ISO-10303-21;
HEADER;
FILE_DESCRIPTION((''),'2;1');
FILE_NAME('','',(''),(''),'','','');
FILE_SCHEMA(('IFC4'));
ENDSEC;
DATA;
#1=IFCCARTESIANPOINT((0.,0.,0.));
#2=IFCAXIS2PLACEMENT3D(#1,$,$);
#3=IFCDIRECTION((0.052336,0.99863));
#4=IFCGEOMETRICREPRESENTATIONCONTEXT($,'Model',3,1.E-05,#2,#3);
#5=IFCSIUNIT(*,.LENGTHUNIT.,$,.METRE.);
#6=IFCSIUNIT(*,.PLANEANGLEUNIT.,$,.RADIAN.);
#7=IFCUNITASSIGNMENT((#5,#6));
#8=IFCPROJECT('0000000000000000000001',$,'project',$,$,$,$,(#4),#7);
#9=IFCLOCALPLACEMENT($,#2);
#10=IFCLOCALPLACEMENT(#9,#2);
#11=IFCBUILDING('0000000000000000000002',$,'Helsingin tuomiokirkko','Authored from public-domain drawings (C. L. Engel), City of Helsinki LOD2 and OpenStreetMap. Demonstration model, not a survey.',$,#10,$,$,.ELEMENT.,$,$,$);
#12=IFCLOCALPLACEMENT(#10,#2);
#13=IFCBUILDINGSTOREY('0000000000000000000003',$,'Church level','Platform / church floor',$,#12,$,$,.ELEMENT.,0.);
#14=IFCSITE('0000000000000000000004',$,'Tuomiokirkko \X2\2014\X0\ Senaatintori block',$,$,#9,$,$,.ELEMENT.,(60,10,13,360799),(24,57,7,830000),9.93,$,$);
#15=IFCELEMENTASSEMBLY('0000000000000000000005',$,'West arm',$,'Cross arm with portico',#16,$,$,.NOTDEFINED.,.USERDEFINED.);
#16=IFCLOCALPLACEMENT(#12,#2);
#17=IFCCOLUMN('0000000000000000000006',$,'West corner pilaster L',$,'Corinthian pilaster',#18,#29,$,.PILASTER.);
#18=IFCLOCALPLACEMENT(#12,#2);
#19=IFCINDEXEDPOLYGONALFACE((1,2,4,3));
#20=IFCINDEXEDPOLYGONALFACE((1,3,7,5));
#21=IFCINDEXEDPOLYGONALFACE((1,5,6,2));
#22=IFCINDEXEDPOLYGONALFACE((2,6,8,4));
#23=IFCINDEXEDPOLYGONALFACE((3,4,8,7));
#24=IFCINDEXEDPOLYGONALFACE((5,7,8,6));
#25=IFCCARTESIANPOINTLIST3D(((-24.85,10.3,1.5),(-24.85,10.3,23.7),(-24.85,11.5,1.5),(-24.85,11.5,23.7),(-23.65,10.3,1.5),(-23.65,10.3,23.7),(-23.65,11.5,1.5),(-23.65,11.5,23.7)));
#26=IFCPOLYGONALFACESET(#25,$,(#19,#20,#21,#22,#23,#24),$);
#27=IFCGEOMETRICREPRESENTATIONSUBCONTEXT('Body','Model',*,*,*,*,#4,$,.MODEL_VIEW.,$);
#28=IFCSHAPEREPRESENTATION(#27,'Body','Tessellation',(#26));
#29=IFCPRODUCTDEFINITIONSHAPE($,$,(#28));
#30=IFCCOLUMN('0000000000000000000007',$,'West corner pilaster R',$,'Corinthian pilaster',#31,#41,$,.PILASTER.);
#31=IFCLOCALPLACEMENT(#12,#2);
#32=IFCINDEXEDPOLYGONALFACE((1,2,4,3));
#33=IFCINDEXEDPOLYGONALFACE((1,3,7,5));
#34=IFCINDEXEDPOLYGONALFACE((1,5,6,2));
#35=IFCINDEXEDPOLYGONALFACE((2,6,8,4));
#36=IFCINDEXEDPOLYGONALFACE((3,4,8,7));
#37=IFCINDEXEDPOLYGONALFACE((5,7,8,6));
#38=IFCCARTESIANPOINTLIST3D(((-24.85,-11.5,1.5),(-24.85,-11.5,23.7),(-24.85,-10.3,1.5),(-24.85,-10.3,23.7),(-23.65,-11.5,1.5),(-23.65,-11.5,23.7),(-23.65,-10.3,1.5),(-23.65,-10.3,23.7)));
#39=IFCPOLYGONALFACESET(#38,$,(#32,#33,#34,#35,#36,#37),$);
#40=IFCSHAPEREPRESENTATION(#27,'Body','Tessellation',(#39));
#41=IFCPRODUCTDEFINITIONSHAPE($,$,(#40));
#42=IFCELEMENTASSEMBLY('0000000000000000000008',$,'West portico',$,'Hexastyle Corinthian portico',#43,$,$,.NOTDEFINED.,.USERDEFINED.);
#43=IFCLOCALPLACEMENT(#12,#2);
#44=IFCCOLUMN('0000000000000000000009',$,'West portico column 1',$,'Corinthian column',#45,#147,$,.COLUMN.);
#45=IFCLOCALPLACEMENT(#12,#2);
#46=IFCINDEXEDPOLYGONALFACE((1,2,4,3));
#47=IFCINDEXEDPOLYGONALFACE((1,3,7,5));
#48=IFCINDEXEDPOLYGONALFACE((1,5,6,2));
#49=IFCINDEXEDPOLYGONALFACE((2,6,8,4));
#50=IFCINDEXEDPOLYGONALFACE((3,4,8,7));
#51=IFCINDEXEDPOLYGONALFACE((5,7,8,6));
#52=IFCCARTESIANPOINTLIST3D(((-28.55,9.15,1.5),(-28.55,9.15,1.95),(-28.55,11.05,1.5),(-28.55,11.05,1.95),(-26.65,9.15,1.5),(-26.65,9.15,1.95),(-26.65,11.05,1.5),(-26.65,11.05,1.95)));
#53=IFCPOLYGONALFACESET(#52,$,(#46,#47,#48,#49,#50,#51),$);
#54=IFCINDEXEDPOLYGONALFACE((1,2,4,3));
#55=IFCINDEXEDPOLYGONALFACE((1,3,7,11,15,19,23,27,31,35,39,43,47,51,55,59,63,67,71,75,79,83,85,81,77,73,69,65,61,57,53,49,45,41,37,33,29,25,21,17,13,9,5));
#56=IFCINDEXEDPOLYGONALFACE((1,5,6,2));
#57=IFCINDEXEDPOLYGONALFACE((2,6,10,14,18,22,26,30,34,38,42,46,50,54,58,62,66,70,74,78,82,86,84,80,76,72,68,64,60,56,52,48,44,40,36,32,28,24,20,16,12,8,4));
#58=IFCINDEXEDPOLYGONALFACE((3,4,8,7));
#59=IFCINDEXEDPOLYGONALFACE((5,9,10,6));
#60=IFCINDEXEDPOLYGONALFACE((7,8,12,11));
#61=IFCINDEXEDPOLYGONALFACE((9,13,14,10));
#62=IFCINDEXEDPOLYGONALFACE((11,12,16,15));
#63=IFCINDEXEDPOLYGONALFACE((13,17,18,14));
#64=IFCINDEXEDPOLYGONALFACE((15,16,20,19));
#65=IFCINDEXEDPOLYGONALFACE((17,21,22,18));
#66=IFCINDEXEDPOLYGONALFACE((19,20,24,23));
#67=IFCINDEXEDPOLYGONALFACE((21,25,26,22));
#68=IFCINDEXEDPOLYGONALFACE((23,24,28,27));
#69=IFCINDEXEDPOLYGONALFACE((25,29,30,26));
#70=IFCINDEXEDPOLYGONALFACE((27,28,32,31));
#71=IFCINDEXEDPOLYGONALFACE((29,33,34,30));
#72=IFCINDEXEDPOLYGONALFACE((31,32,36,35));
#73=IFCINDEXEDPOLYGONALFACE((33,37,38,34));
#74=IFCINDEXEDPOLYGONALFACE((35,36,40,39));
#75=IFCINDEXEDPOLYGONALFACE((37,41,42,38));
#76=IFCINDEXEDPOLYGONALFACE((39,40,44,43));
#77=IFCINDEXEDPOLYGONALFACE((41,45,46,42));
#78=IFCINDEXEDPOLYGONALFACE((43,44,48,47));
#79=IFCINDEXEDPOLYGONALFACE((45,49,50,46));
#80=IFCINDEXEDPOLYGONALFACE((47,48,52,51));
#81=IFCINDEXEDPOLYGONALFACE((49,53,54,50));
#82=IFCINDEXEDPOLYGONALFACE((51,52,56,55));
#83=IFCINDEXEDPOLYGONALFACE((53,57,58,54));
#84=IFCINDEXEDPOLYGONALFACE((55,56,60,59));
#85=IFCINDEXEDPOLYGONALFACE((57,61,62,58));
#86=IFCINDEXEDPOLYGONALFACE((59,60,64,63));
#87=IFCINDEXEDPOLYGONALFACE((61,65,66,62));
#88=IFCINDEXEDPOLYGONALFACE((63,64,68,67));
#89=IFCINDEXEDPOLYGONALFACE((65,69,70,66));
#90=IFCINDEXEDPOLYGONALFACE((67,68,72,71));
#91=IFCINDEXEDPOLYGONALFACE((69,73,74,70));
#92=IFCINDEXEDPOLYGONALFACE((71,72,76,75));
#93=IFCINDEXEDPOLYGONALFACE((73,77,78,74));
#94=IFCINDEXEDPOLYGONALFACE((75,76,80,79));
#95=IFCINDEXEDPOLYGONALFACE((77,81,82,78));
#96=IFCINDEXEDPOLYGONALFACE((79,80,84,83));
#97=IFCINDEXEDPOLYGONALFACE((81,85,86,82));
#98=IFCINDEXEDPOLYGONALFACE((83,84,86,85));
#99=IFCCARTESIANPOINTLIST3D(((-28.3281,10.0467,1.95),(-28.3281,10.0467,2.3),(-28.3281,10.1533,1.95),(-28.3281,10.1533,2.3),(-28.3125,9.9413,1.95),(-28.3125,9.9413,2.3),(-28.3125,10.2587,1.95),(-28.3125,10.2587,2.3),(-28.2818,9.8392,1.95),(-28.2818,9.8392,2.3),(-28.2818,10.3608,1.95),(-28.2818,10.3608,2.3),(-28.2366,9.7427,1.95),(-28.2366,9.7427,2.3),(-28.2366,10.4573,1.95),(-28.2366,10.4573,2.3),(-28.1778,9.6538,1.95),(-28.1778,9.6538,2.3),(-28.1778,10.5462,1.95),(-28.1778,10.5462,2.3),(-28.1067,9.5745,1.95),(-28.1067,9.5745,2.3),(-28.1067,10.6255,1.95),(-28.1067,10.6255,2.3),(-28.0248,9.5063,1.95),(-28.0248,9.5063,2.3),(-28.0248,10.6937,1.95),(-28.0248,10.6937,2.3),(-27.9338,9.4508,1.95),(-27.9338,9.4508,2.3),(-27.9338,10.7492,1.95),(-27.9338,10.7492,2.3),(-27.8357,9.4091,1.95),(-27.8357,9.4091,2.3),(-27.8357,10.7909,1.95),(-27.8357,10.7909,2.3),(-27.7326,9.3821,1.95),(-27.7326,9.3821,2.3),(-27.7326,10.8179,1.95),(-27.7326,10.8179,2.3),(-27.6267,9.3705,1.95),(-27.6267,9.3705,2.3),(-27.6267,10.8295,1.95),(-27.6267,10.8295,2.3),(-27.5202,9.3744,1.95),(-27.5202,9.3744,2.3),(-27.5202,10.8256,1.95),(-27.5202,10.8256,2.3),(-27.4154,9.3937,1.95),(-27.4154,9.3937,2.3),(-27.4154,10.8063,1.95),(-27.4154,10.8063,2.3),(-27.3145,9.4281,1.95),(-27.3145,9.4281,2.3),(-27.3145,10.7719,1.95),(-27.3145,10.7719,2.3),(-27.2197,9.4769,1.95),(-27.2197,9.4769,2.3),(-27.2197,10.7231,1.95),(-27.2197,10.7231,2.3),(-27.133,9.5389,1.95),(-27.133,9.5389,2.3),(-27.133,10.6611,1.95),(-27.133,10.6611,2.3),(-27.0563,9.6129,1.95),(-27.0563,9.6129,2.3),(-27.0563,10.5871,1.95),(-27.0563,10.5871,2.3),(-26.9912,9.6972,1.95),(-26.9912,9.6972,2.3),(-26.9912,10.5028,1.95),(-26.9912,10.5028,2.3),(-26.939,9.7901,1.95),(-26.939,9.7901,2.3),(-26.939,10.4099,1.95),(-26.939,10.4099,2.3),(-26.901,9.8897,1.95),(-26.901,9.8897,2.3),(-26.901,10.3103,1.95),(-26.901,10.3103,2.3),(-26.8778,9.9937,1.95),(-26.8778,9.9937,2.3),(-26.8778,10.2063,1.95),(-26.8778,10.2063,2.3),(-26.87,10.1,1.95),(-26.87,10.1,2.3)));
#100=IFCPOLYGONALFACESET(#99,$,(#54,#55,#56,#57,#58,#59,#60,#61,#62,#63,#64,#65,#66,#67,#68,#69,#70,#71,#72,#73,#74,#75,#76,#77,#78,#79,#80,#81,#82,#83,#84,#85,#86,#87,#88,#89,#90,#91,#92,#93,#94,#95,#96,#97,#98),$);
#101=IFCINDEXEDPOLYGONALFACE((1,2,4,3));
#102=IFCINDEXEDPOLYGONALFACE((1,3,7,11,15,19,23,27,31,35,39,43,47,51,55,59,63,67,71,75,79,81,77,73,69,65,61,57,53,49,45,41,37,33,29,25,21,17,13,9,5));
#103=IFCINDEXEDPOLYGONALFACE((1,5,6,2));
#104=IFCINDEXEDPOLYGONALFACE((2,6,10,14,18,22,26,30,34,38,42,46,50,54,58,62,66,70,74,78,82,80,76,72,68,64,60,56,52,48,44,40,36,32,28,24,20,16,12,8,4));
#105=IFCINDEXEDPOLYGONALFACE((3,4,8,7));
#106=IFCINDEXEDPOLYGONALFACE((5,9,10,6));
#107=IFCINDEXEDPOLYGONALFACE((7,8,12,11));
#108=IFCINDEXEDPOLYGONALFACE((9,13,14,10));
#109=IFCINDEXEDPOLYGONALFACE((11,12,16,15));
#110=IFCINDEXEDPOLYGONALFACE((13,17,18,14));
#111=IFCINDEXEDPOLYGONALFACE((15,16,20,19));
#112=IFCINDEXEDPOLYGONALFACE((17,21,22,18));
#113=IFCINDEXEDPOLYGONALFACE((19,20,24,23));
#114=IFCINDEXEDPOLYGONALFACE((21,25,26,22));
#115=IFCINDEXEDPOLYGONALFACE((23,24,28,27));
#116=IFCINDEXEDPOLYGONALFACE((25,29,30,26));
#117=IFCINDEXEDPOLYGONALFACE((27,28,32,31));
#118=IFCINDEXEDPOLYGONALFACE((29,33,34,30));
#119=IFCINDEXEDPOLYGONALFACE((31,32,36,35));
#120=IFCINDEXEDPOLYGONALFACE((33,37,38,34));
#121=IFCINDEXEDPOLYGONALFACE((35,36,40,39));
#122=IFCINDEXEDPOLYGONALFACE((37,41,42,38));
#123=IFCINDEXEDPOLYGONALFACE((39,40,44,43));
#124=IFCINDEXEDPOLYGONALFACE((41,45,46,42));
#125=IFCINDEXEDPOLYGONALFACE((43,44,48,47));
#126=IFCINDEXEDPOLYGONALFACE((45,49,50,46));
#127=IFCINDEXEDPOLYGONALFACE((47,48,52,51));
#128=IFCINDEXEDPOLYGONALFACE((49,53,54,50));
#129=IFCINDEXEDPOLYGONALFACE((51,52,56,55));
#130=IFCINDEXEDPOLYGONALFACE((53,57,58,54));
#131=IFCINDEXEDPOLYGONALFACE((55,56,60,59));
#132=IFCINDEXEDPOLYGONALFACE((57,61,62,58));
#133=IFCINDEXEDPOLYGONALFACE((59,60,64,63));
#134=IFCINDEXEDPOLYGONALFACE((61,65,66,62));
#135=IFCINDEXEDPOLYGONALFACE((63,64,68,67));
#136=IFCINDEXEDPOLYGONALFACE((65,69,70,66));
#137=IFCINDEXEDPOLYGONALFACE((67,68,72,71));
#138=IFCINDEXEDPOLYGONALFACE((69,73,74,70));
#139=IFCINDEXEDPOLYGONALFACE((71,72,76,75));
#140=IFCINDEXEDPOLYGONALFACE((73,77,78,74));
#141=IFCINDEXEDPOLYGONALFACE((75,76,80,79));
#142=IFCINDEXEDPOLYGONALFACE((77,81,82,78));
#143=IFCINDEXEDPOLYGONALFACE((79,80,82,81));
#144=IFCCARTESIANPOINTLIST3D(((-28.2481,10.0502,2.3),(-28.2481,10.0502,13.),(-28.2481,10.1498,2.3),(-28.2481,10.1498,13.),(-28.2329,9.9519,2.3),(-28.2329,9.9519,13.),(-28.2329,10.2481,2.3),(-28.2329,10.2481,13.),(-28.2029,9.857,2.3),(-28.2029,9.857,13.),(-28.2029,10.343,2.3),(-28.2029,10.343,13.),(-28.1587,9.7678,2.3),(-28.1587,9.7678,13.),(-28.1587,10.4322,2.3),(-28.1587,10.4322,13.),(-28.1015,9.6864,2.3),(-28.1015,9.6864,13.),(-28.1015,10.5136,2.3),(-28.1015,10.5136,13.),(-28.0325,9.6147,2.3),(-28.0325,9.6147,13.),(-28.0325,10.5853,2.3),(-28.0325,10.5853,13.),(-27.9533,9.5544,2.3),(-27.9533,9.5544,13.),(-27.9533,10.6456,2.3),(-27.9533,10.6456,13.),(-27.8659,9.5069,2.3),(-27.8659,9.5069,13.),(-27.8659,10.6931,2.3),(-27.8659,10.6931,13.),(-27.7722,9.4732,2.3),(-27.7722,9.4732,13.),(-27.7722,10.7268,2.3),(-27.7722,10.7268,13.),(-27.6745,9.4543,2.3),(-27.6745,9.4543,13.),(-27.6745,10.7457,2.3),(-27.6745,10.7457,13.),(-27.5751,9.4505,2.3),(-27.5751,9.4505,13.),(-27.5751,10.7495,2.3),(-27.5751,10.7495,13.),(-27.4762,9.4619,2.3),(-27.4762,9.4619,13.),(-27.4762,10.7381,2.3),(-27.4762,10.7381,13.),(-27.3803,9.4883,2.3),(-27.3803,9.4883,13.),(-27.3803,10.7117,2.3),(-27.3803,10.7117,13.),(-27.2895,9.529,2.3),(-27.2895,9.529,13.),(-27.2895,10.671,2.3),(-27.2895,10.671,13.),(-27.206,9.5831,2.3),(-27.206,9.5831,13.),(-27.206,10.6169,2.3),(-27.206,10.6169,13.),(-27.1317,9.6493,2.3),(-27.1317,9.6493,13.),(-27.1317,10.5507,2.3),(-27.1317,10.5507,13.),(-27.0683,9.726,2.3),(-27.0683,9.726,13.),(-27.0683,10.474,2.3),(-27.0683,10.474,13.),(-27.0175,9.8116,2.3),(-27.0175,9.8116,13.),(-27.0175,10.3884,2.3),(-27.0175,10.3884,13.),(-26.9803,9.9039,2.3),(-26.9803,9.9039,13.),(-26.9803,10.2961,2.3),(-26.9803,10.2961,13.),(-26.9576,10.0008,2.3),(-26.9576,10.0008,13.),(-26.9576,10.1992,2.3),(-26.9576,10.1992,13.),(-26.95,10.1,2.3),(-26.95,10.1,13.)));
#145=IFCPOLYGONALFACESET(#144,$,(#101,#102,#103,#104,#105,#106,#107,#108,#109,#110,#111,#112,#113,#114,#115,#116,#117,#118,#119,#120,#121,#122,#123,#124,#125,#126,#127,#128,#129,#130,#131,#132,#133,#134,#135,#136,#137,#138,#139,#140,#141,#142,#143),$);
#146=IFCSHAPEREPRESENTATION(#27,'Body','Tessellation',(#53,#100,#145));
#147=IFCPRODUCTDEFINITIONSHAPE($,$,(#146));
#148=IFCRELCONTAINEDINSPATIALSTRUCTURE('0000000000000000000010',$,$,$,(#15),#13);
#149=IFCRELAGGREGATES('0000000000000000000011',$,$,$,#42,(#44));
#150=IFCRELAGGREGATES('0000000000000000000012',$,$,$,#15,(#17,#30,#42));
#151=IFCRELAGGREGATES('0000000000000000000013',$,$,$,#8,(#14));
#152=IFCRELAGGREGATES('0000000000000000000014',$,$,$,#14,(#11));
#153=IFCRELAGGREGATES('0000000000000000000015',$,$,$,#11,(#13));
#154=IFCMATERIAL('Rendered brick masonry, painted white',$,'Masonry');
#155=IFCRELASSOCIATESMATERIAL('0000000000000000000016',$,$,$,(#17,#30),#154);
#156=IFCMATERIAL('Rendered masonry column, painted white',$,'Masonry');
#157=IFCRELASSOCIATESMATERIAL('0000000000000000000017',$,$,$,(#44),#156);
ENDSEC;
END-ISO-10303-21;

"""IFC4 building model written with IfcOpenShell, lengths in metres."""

from ifc_helpers import new_model, si_unit, direction, frame, origin, origin_2d_with_axis, place, context, subcontext, project, spatial, rectangle, circle, extrude, material, element, aggregate, save


model = new_model("IFC4")

# Units and contexts
model_context = context("Model", 3, precision=1e-05, world=origin(), true_north=direction((0.052336, 0.99863)))
body_context = subcontext(model_context, "Body", "Model", "MODEL_VIEW")
ifc_project = project(units=[si_unit("LENGTHUNIT", "METRE"), si_unit("PLANEANGLEUNIT", "RADIAN")], contexts=[model_context])

# Site, building, storey
site_placement = place(None, origin())
site = spatial("IfcSite", under=ifc_project, at=site_placement, Name="Tuomiokirkko — Senaatintori block", CompositionType="ELEMENT", RefLatitude=(60, 10, 13, 360799), RefLongitude=(24, 57, 7, 830000), RefElevation=9.93)
building_placement = place(site_placement, origin())
building = spatial("IfcBuilding", under=site, at=building_placement, Name="Helsingin tuomiokirkko", Description="Authored from public-domain drawings (C. L. Engel), City of Helsinki LOD2 and OpenStreetMap. Demonstration model, not a survey.", CompositionType="ELEMENT")
storey_placement = place(building_placement, origin())
storey = spatial("IfcBuildingStorey", under=building, at=storey_placement, Name="Church level", Description="Platform / church floor", CompositionType="ELEMENT", Elevation=0.0)

# Element assemblies, columns
assembly_1_placement = place(building_placement, origin())
assembly_1 = element("IfcElementAssembly", 1, at=assembly_1_placement, inside=storey, Name="West arm", ObjectType="Cross arm with portico", AssemblyPlace="NOTDEFINED", PredefinedType="USERDEFINED")
ifc_material_1 = material(Name="Rendered brick masonry, painted white", Category="Masonry")
column_1_placement = place(building_placement, origin())
column_1 = element("IfcColumn", 2, at=column_1_placement, material=ifc_material_1, Name="West corner pilaster L", ObjectType="Corinthian pilaster", PredefinedType="PILASTER", context=body_context, shape_type="SweptSolid", body=[
    extrude(rectangle(XDim=1.2, YDim=1.2, at=origin_2d_with_axis()), frame((-24.25, 10.9, 1.5)), (0.0, 0.0, 1.0), 22.2),
])
column_2_placement = place(building_placement, origin())
column_2 = element("IfcColumn", 3, at=column_2_placement, material=ifc_material_1, Name="West corner pilaster R", ObjectType="Corinthian pilaster", PredefinedType="PILASTER", context=body_context, shape_type="SweptSolid", body=[
    extrude(rectangle(XDim=1.2, YDim=1.2, at=origin_2d_with_axis()), frame((-24.25, -10.9, 1.5)), (0.0, 0.0, 1.0), 22.2),
])
assembly_2_placement = place(building_placement, origin())
assembly_2 = element("IfcElementAssembly", 4, at=assembly_2_placement, Name="West portico", ObjectType="Hexastyle Corinthian portico", AssemblyPlace="NOTDEFINED", PredefinedType="USERDEFINED")
ifc_material_2 = material(Name="Rendered masonry column, painted white", Category="Masonry")
column_3_placement = place(building_placement, origin())
column_3 = element("IfcColumn", 5, at=column_3_placement, material=ifc_material_2, Name="West portico column 1", ObjectType="Corinthian column", PredefinedType="COLUMN", context=body_context, shape_type="SweptSolid", body=[
    extrude(rectangle(XDim=1.9, YDim=1.9, at=origin_2d_with_axis()), frame((-27.6, 10.1, 1.5)), (0.0, 0.0, 1.0), 0.45),
    extrude(circle(Radius=0.73, at=origin_2d_with_axis()), frame((-27.6, 10.1, 1.95)), (0.0, 0.0, 1.0), 0.35),
    extrude(circle(Radius=0.65, at=origin_2d_with_axis()), frame((-27.6, 10.1, 2.3)), (0.0, 0.0, 1.0), 10.7),
])

aggregate(assembly_2, [column_3])

aggregate(assembly_1, [column_1, column_2, assembly_2])

save(model, "model.ifc")
